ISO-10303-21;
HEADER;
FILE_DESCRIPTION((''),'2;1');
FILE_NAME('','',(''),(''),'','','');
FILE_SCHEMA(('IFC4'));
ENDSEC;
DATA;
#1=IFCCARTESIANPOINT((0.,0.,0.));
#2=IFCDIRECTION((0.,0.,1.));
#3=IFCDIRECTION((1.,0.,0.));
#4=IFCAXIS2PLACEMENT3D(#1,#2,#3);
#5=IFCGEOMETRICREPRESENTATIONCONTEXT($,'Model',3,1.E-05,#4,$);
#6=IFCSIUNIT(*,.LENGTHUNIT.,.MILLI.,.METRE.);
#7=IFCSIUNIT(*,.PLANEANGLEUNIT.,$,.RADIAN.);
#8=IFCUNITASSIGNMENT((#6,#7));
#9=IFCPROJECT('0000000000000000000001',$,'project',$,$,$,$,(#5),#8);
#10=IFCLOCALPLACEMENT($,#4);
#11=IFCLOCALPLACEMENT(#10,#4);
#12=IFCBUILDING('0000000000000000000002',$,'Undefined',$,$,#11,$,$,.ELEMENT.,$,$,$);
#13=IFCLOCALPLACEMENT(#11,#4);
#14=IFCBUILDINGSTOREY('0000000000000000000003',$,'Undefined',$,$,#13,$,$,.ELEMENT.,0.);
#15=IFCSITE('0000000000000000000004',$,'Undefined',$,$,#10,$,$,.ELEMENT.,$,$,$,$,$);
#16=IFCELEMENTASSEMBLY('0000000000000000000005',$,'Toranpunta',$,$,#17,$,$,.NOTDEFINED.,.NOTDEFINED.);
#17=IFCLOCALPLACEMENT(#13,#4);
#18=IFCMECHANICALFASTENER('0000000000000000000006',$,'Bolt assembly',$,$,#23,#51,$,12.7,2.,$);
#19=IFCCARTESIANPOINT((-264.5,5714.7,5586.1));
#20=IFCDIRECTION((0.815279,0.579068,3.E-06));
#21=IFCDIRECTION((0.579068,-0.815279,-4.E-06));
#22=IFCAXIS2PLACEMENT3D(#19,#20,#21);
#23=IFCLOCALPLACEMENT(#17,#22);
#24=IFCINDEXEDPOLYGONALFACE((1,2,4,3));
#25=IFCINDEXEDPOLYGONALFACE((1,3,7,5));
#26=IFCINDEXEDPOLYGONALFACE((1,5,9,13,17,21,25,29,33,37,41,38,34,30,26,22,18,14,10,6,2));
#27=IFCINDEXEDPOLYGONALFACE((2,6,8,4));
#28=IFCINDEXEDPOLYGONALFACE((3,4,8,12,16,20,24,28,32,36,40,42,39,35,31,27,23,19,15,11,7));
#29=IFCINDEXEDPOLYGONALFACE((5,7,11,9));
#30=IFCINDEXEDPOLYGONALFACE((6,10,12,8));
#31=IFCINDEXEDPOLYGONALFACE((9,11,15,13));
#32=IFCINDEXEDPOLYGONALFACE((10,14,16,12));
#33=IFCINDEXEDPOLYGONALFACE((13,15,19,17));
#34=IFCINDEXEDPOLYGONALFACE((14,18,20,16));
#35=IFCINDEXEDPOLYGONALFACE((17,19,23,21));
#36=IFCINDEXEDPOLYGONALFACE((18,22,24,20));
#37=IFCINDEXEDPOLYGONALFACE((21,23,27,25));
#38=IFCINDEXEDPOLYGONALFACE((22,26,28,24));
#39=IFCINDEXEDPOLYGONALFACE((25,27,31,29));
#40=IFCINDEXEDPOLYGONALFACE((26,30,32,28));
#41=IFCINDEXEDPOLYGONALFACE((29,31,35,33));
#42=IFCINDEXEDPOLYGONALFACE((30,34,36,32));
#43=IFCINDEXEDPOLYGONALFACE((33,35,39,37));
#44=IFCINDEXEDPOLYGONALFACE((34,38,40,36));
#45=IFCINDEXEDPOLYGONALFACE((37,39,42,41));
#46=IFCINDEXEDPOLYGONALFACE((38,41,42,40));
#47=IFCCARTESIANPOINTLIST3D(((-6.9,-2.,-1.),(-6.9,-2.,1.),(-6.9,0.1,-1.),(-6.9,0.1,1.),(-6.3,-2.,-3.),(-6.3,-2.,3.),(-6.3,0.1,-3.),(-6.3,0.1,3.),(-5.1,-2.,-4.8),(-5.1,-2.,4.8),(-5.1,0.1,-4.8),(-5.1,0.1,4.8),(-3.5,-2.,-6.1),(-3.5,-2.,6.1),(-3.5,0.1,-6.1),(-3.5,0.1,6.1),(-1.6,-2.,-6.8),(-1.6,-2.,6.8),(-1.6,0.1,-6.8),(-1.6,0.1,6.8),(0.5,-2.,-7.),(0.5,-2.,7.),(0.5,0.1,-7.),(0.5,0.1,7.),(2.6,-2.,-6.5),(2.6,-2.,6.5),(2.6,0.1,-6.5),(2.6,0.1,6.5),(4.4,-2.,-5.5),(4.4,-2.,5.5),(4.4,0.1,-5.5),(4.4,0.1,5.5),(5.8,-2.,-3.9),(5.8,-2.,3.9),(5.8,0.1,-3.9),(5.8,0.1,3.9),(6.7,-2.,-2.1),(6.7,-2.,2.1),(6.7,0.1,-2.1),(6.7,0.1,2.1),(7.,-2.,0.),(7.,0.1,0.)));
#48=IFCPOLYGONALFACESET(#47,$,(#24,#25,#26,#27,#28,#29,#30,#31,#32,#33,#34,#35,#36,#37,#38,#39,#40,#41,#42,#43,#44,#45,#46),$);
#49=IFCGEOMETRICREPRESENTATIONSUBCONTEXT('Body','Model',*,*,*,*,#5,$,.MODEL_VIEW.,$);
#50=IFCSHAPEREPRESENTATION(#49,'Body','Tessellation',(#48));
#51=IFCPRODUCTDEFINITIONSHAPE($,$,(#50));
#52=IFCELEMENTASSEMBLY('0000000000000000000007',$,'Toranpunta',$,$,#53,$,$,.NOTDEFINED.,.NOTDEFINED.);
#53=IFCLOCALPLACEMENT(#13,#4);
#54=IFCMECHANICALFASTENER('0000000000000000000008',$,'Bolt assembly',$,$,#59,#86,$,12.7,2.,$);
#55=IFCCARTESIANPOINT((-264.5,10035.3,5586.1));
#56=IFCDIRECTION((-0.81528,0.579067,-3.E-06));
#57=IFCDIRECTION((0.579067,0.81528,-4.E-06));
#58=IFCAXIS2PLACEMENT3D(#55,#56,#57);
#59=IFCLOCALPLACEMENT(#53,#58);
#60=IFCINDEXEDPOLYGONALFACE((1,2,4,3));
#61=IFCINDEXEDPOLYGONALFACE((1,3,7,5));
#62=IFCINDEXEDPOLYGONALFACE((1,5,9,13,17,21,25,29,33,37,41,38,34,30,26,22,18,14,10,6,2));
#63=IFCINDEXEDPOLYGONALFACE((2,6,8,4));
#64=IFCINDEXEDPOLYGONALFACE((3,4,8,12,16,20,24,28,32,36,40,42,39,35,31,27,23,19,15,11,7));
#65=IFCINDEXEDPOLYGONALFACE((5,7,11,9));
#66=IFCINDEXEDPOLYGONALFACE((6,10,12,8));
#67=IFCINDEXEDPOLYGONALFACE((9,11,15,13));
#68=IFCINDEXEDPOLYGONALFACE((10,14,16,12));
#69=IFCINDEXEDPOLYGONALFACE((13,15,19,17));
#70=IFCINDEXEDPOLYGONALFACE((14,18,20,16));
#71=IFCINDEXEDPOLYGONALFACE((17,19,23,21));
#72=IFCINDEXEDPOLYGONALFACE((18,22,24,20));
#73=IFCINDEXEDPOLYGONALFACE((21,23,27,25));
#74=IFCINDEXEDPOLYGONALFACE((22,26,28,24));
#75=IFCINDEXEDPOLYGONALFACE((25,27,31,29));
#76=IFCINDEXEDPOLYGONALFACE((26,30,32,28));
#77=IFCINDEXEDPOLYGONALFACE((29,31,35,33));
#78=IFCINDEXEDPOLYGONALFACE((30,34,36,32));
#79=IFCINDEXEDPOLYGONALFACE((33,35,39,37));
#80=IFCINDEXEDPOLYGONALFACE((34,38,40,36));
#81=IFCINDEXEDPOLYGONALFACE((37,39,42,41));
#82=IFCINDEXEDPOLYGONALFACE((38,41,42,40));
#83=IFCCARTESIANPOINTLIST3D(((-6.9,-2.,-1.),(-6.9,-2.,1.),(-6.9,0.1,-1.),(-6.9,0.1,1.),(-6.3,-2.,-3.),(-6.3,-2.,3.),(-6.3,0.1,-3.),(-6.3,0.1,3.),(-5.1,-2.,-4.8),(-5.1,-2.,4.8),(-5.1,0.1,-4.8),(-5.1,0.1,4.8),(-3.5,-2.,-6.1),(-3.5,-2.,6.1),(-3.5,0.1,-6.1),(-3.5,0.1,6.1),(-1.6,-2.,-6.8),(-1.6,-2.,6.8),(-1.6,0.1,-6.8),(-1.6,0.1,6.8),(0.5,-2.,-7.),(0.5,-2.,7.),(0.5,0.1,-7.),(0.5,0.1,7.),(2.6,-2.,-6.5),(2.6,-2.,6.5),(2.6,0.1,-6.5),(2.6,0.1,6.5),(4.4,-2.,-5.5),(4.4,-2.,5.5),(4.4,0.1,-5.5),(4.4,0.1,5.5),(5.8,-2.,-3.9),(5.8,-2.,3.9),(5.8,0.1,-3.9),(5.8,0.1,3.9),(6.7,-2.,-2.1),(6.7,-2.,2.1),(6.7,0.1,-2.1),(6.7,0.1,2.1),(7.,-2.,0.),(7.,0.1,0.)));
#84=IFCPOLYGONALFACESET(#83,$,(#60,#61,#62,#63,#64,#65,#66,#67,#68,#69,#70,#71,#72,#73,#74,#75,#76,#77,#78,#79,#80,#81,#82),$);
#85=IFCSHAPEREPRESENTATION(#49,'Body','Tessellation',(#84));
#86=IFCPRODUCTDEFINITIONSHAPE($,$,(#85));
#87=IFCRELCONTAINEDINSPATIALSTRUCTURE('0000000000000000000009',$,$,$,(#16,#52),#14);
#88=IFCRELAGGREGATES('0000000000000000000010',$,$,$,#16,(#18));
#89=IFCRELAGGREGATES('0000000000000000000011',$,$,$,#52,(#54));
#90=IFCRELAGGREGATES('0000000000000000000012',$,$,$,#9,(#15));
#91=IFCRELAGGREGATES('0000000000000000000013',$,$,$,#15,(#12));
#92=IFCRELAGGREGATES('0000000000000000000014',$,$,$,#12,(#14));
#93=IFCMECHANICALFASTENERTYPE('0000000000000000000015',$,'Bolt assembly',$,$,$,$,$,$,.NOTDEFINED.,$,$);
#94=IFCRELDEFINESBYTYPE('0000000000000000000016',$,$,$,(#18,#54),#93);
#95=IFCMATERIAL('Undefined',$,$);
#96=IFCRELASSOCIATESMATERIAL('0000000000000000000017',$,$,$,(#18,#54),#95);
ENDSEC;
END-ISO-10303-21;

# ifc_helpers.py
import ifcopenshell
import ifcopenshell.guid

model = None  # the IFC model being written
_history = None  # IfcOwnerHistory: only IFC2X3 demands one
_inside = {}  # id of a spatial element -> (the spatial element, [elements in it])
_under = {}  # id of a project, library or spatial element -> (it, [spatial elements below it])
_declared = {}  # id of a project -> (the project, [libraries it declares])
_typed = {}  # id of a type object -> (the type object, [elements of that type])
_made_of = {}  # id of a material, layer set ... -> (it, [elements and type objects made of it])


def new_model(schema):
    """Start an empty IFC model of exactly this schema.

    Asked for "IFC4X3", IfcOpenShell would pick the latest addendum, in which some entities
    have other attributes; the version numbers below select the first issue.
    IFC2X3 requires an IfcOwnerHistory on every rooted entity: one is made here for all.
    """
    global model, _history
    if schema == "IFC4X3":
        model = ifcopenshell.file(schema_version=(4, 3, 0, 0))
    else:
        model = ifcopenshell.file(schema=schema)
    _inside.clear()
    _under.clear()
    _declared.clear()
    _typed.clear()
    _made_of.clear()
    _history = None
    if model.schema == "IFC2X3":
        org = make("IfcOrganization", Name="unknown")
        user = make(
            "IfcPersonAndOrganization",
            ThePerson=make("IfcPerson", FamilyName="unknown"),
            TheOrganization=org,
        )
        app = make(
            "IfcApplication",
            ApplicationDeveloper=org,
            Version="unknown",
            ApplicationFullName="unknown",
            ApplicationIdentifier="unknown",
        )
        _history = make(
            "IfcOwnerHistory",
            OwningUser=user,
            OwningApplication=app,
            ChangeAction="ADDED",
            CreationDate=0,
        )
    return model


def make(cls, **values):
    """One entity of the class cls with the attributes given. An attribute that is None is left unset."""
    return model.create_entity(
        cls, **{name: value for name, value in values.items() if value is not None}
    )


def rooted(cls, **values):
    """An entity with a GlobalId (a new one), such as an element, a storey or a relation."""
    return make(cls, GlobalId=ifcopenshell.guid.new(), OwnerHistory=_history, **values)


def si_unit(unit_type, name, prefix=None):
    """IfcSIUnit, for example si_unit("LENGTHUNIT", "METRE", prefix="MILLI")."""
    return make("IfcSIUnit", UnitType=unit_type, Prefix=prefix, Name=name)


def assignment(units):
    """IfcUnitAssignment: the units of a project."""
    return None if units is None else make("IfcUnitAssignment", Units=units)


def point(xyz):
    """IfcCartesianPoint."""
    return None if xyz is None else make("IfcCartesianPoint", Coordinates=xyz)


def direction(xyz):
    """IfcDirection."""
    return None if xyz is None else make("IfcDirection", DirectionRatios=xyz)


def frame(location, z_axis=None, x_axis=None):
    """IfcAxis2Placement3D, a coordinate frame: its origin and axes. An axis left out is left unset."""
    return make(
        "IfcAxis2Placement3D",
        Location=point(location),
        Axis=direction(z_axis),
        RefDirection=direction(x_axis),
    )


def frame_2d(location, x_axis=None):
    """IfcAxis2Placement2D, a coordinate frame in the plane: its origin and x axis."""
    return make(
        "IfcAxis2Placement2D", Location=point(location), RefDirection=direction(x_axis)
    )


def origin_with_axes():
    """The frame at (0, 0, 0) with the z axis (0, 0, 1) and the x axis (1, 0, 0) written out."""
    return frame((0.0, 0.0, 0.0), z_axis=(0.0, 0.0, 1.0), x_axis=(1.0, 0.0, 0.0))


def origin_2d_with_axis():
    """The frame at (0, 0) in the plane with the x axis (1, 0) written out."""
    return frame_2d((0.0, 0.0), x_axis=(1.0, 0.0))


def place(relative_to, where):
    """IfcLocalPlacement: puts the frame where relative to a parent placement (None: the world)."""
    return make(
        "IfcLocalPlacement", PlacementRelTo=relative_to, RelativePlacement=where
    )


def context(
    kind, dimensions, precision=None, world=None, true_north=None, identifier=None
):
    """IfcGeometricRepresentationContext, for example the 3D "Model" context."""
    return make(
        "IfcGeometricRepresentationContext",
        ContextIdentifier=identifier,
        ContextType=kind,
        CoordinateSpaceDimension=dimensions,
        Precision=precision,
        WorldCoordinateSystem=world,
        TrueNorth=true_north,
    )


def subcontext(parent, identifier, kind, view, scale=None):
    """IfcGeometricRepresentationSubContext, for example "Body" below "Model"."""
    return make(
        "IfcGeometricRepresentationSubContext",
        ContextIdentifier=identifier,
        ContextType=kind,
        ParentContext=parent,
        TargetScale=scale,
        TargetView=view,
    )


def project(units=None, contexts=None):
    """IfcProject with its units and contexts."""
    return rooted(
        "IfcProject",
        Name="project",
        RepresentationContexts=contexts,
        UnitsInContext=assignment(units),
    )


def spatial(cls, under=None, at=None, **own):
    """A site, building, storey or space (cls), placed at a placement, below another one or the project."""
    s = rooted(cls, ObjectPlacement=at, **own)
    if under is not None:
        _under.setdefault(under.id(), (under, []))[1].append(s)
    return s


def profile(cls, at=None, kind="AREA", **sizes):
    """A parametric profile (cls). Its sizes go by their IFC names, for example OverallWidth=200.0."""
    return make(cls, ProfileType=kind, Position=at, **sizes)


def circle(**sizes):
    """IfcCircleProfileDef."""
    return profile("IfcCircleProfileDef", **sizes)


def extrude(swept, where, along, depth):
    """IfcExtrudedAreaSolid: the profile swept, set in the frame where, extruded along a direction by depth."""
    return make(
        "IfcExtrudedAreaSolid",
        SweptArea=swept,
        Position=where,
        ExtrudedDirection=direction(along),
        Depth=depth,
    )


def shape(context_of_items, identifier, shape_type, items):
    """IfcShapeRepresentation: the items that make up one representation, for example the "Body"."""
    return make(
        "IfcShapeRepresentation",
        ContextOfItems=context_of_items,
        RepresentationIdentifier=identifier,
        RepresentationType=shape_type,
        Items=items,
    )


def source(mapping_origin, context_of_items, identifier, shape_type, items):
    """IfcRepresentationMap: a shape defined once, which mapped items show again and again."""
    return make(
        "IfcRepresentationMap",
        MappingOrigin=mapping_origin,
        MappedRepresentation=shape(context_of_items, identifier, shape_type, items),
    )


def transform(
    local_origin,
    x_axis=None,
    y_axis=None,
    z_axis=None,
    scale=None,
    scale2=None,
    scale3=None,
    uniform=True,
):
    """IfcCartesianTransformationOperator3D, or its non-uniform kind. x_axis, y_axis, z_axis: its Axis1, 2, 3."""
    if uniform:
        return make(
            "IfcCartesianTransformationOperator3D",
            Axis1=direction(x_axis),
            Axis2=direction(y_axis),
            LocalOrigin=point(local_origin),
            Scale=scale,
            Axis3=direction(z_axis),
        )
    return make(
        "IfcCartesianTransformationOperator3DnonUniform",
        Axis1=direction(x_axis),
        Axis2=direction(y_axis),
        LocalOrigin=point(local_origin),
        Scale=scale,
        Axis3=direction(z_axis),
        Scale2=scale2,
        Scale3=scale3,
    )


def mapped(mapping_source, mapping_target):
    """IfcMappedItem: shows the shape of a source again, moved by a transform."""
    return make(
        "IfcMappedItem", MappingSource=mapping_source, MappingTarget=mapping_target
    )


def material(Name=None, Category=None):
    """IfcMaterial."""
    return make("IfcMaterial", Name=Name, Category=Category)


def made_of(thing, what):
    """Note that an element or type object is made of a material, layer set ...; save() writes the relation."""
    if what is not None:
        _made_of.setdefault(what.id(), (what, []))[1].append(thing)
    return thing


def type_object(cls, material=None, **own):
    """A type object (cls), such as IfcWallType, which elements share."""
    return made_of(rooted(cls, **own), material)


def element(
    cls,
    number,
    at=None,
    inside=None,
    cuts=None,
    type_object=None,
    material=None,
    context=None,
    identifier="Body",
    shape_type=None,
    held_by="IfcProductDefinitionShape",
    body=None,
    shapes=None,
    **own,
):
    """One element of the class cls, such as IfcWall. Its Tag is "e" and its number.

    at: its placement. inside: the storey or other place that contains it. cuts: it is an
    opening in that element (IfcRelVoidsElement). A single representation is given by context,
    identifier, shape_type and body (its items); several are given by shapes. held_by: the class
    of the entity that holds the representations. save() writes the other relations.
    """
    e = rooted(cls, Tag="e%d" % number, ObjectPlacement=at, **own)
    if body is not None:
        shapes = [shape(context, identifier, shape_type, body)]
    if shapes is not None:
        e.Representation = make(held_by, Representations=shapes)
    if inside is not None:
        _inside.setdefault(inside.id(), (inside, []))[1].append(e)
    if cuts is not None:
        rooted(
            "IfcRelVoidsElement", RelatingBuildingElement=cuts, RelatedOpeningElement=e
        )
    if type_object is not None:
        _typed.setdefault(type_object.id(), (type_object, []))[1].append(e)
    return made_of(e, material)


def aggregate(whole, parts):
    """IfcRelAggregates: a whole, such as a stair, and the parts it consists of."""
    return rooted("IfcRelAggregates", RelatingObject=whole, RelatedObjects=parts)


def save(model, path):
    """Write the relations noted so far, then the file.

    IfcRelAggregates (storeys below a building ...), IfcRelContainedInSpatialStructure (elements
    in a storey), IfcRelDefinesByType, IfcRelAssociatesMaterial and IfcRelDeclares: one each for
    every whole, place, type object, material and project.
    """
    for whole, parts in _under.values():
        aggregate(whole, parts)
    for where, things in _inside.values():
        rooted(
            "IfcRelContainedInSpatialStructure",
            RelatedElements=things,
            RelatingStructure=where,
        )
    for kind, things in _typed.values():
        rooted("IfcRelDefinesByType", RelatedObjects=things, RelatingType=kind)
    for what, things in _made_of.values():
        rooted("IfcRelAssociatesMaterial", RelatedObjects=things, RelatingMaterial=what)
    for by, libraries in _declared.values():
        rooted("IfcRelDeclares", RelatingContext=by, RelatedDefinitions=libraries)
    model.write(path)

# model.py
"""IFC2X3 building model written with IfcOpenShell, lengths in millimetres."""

from ifc_helpers import new_model, si_unit, frame, origin_with_axes, origin_2d_with_axis, place, context, subcontext, project, spatial, circle, extrude, source, transform, mapped, material, type_object, element, aggregate, save


model = new_model("IFC2X3")

# Units and contexts
model_context = context("Model", 3, precision=1e-05, world=origin_with_axes())
body_context = subcontext(model_context, "Body", "Model", "MODEL_VIEW")
ifc_project = project(units=[si_unit("LENGTHUNIT", "METRE", prefix="MILLI"), si_unit("PLANEANGLEUNIT", "RADIAN")], contexts=[model_context])

# Site, building, storey
site_placement = place(None, origin_with_axes())
site = spatial("IfcSite", under=ifc_project, at=site_placement, Name="Undefined", CompositionType="ELEMENT")
building_placement = place(site_placement, origin_with_axes())
building = spatial("IfcBuilding", under=site, at=building_placement, Name="Undefined", CompositionType="ELEMENT")
storey_placement = place(building_placement, origin_with_axes())
storey = spatial("IfcBuildingStorey", under=building, at=storey_placement, Name="Undefined", CompositionType="ELEMENT", Elevation=0.0)

# Element assembly, mechanical fastener
assembly_1_placement = place(storey_placement, origin_with_axes())
assembly_1 = element("IfcElementAssembly", 1, at=assembly_1_placement, inside=storey, Name="Toranpunta", AssemblyPlace="NOTDEFINED", PredefinedType="NOTDEFINED")
ifc_material_1 = material(Name="Undefined")
mechanical_fastener_type = type_object("IfcMechanicalFastenerType", Name="Bolt assembly")
shared_shape_1 = source(origin_with_axes(), body_context, "Body", "SweptSolid", [
    extrude(circle(Radius=7.0, at=origin_2d_with_axis()), frame((0.0, -2.0, 0.0), z_axis=(0.0, 1.0, 0.0), x_axis=(1.0, 0.0, 0.0)), (0.0, 0.0, 1.0), 2.1),
])
mechanical_fastener_1_placement = place(assembly_1_placement, frame((-264.5, 5714.7, 5586.1), z_axis=(0.815279, 0.579068, 0.000003), x_axis=(0.579068, -0.815279, -0.000004)))
mechanical_fastener_1 = element("IfcMechanicalFastener", 2, at=mechanical_fastener_1_placement, type_object=mechanical_fastener_type, material=ifc_material_1, Name="Bolt assembly", NominalDiameter=12.7, NominalLength=2.0, context=body_context, shape_type="MappedRepresentation", body=[
    mapped(shared_shape_1, transform((0.0, 0.0, 0.0))),
])
aggregate(assembly_1, [mechanical_fastener_1])

# Element assembly, mechanical fastener
assembly_2_placement = place(storey_placement, origin_with_axes())
assembly_2 = element("IfcElementAssembly", 3, at=assembly_2_placement, inside=storey, Name="Toranpunta", AssemblyPlace="NOTDEFINED", PredefinedType="NOTDEFINED")
mechanical_fastener_2_placement = place(assembly_2_placement, frame((-264.5, 10035.3, 5586.1), z_axis=(-0.81528, 0.579067, -0.000003), x_axis=(0.579067, 0.81528, -0.000004)))
mechanical_fastener_2 = element("IfcMechanicalFastener", 4, at=mechanical_fastener_2_placement, type_object=mechanical_fastener_type, material=ifc_material_1, Name="Bolt assembly", NominalDiameter=12.7, NominalLength=2.0, context=body_context, shape_type="MappedRepresentation", body=[
    mapped(shared_shape_1, transform((0.0, 0.0, 0.0))),
])
aggregate(assembly_2, [mechanical_fastener_2])

save(model, "model.ifc")
